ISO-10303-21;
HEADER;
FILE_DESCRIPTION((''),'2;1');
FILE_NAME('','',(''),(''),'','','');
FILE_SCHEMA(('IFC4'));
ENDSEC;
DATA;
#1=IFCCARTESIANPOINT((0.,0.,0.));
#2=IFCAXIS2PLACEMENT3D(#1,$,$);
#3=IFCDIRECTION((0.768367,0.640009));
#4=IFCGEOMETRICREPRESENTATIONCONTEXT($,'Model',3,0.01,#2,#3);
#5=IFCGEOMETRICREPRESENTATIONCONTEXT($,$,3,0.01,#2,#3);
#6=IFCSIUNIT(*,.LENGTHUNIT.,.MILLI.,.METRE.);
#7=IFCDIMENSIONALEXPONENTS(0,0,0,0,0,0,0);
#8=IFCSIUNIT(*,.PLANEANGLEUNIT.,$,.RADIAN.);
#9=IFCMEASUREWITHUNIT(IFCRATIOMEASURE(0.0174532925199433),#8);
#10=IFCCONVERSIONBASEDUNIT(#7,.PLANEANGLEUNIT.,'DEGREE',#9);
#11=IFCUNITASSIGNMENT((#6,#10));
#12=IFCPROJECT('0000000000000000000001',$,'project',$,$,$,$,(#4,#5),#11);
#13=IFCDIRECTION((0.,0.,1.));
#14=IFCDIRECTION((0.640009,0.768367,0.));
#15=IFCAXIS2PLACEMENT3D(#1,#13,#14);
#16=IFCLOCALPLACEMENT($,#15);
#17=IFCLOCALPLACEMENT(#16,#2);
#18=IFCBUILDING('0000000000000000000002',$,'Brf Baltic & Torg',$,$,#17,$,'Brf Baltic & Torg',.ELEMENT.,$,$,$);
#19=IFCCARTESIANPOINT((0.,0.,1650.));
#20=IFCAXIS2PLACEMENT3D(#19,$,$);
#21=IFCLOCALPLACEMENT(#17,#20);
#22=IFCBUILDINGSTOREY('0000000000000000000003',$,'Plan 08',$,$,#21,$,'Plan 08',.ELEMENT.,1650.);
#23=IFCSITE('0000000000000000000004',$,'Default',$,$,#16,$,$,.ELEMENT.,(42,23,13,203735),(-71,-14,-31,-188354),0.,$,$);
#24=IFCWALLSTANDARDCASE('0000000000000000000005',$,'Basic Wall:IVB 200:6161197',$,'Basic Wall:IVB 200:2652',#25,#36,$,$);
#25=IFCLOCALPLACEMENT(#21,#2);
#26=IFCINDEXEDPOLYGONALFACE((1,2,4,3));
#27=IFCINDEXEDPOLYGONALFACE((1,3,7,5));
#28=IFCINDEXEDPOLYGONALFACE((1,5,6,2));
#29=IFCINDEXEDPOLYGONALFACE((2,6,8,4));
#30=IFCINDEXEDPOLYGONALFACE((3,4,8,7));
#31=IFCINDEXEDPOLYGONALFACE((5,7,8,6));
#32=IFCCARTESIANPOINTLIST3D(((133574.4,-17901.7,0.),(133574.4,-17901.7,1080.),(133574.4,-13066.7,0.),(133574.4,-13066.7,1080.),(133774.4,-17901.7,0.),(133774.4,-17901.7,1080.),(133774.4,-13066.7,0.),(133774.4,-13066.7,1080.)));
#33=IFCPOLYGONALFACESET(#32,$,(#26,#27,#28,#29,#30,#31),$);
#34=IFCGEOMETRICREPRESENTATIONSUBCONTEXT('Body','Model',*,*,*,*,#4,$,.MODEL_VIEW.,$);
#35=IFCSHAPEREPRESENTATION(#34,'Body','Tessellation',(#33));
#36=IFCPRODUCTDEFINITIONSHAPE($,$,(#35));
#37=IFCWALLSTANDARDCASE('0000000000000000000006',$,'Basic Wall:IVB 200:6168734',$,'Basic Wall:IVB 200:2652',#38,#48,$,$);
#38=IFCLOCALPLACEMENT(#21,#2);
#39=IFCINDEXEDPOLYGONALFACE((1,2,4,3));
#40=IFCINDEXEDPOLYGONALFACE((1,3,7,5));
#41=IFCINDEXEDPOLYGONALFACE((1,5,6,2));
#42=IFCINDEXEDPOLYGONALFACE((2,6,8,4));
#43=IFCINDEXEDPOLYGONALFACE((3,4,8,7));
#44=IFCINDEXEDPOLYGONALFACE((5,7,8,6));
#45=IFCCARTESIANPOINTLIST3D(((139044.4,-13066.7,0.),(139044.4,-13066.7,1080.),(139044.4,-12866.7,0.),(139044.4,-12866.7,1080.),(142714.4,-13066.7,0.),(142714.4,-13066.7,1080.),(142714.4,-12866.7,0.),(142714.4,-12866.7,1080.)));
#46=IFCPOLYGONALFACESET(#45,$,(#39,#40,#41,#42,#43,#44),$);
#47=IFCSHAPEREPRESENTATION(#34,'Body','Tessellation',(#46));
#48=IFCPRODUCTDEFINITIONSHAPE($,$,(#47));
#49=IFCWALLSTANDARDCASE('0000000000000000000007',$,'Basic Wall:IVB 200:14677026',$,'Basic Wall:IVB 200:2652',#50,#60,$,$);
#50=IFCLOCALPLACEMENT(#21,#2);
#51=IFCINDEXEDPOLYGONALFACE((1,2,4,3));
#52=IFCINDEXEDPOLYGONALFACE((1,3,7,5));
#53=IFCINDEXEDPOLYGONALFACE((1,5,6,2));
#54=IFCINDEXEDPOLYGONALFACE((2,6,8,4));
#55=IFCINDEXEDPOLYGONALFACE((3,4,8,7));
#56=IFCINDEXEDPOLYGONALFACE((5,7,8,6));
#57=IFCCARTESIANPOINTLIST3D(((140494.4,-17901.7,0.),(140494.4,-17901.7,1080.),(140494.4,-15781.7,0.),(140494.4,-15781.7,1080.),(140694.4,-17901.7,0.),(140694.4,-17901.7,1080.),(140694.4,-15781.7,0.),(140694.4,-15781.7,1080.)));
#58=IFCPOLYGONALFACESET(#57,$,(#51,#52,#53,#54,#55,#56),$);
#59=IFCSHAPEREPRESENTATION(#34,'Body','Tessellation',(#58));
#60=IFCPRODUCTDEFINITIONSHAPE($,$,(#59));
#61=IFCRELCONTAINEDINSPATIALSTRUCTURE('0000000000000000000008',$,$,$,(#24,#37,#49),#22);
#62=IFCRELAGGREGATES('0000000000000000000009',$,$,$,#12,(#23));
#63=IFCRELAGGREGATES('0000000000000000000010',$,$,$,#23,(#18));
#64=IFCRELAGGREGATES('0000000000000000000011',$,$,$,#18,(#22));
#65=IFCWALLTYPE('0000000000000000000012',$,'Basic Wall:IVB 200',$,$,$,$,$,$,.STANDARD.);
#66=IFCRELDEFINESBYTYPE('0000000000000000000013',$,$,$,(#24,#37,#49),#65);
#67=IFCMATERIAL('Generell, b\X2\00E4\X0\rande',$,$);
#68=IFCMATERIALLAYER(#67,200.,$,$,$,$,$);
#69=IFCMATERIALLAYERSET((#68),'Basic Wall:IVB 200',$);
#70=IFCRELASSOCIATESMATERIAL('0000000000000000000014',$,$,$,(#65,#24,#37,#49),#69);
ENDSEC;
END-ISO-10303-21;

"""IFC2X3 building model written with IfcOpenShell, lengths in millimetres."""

from ifc_helpers import new_model, entity, si_unit, converted_unit, direction, frame, frame_2d, origin, place, context, subcontext, project, spatial, rectangle, extrude, clip, halfspace, material, layer, layer_set, layer_usage, type_object, element, save


model = new_model("IFC2X3")

# Units and contexts
model_context = context("Model", 3, precision=0.01, world=origin(), true_north=direction((0.768367, 0.640009)))
context_of_model = context(None, 3, precision=0.01, world=origin(), true_north=direction((0.768367, 0.640009)))
body_context = subcontext(model_context, "Body", "Model", "MODEL_VIEW")
ifc_project = project(units=[si_unit("LENGTHUNIT", "METRE", prefix="MILLI"), converted_unit("PLANEANGLEUNIT", "DEGREE", entity("IfcRatioMeasure", 0.0174532925199433), si_unit("PLANEANGLEUNIT", "RADIAN"), dimensions=[0, 0, 0, 0, 0, 0, 0])], contexts=[model_context, context_of_model])

# Site, building, storey
site_placement = place(None, frame((0.0, 0.0, 0.0), z_axis=(0.0, 0.0, 1.0), x_axis=(0.640009, 0.768367, 0.0)))
site = spatial("IfcSite", under=ifc_project, at=site_placement, Name="Default", CompositionType="ELEMENT", RefLatitude=(42, 23, 13, 203735), RefLongitude=(-71, -14, -31, -188354), RefElevation=0.0)
building_placement = place(site_placement, origin())
building = spatial("IfcBuilding", under=site, at=building_placement, Name="Brf Baltic & Torg", LongName="Brf Baltic & Torg", CompositionType="ELEMENT")
storey_placement = place(building_placement, frame((0.0, 0.0, 1650.0)))
storey = spatial("IfcBuildingStorey", under=building, at=storey_placement, Name="Plan 08", LongName="Plan 08", CompositionType="ELEMENT", Elevation=1650.0)

# Shared definitions
ifc_material_1 = material(Name="Generell, bärande")

# Shared definitions
ifc_layer_1 = layer(ifc_material_1, 200.0)
ifc_layer_set_1 = layer_set([ifc_layer_1], Name="Basic Wall:IVB 200")
wall_type = type_object("IfcWallType", Name="Basic Wall:IVB 200", PredefinedType="STANDARD", material=ifc_layer_set_1)

# Walls
ifc_layer_usage_1 = layer_usage(ifc_layer_set_1, "AXIS2", "NEGATIVE", 100.0)
wall_1_placement = place(storey_placement, frame((133674.4, -17901.7, 0.0), z_axis=(0.0, 0.0, 1.0), x_axis=(0.0, 1.0, 0.0)))
element("IfcWallStandardCase", 1, at=wall_1_placement, inside=storey, type_object=wall_type, material=ifc_layer_usage_1, Name="Basic Wall:IVB 200:6161197", ObjectType="Basic Wall:IVB 200:2652", context=body_context, shape_type="Clipping", body=[
    clip(extrude(rectangle(XDim=4835.0, YDim=200.0, at=frame_2d((2417.5, 0.0), x_axis=(-1.0, 0.0))), origin(), (0.0, 0.0, 1.0), 1080.0), halfspace(origin(), True)),
])
ifc_layer_usage_2 = layer_usage(ifc_layer_set_1, "AXIS2", "NEGATIVE", 100.0)
wall_2_placement = place(storey_placement, frame((142714.4, -12966.7, 0.0), z_axis=(0.0, 0.0, 1.0), x_axis=(-1.0, 0.0, 0.0)))
element("IfcWallStandardCase", 2, at=wall_2_placement, inside=storey, type_object=wall_type, material=ifc_layer_usage_2, Name="Basic Wall:IVB 200:6168734", ObjectType="Basic Wall:IVB 200:2652", context=body_context, shape_type="Clipping", body=[
    clip(extrude(rectangle(XDim=3670.0, YDim=200.0, at=frame_2d((1835.0, 0.0), x_axis=(-1.0, 0.0))), origin(), (0.0, 0.0, 1.0), 1080.0), halfspace(origin(), True)),
])

# Wall
ifc_layer_usage_3 = layer_usage(ifc_layer_set_1, "AXIS2", "NEGATIVE", 100.0)
wall_3_placement = place(storey_placement, frame((140594.4, -15781.7, 0.0), z_axis=(0.0, 0.0, 1.0), x_axis=(0.0, -1.0, 0.0)))
element("IfcWallStandardCase", 3, at=wall_3_placement, inside=storey, type_object=wall_type, material=ifc_layer_usage_3, Name="Basic Wall:IVB 200:14677026", ObjectType="Basic Wall:IVB 200:2652", context=body_context, shape_type="Clipping", body=[
    clip(extrude(rectangle(XDim=2120.0, YDim=200.0, at=frame_2d((1060.0, 0.0), x_axis=(-1.0, 0.0))), origin(), (0.0, 0.0, 1.0), 1080.0), halfspace(origin(), True)),
])

save(model, "model.ifc")
